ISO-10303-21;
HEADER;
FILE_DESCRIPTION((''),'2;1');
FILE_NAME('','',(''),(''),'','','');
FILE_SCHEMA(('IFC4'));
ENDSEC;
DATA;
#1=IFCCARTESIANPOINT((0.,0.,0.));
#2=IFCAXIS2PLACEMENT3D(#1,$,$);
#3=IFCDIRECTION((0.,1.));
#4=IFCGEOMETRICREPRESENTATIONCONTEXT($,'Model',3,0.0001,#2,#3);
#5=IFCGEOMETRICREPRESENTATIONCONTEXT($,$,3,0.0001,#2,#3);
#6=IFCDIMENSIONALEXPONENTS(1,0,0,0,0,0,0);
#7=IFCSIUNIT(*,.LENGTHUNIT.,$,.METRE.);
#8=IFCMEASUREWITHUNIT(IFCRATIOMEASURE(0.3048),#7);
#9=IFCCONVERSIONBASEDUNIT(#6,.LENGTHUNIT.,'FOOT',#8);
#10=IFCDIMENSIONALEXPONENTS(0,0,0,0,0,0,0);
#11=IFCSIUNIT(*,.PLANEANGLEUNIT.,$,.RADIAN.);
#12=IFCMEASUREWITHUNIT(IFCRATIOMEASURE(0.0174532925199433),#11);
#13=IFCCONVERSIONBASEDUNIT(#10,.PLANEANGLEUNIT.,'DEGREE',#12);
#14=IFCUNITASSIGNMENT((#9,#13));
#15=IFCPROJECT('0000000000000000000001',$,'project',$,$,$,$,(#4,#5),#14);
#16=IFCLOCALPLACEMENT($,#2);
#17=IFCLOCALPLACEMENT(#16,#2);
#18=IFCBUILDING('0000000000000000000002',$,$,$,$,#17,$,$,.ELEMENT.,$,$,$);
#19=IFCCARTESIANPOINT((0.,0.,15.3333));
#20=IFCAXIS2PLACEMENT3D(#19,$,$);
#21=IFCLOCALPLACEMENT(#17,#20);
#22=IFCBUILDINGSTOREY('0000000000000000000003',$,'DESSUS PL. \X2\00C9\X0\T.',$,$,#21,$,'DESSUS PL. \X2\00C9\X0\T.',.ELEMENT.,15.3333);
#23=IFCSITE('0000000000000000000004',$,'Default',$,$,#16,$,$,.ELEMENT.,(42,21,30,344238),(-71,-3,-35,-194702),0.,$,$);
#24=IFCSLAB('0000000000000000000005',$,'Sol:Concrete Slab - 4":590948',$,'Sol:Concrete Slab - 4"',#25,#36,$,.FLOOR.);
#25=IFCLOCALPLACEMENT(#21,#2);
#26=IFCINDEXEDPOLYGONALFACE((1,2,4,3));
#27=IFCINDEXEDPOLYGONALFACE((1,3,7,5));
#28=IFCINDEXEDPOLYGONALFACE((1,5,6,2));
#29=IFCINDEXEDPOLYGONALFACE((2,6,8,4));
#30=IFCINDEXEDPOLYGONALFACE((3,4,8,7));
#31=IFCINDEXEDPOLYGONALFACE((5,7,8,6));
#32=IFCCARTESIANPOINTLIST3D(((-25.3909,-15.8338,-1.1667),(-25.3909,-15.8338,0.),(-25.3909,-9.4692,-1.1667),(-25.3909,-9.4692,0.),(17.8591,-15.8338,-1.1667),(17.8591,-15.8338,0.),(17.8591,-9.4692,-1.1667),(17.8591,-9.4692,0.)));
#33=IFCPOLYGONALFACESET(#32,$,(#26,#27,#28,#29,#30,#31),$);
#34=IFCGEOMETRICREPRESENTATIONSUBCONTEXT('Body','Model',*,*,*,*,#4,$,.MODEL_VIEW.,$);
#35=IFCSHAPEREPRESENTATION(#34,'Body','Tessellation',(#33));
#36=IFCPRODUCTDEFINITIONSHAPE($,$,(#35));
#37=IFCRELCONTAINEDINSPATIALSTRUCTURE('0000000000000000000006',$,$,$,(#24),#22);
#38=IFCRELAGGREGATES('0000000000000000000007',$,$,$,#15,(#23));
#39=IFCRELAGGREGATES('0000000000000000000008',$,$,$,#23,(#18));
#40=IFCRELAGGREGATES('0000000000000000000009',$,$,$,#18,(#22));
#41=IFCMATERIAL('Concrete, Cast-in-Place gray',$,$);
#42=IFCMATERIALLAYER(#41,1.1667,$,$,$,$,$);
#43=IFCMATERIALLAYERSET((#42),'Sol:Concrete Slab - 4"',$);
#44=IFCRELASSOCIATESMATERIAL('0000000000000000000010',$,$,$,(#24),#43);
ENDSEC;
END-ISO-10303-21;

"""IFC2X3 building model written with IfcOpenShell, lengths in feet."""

from ifc_helpers import new_model, entity, si_unit, converted_unit, direction, frame, frame_2d, origin, place, context, subcontext, project, spatial, rectangle, extrude, material, layer, layer_set, layer_usage, element, save


model = new_model("IFC2X3")

# Units and contexts
model_context = context("Model", 3, precision=0.0001, world=origin(), true_north=direction((0.0, 1.0)))
context_of_model = context(None, 3, precision=0.0001, world=origin(), true_north=direction((0.0, 1.0)))
body_context = subcontext(model_context, "Body", "Model", "MODEL_VIEW")
ifc_project = project(units=[converted_unit("LENGTHUNIT", "FOOT", entity("IfcRatioMeasure", 0.3048), si_unit("LENGTHUNIT", "METRE"), dimensions=[1, 0, 0, 0, 0, 0, 0]), converted_unit("PLANEANGLEUNIT", "DEGREE", entity("IfcRatioMeasure", 0.0174532925199433), si_unit("PLANEANGLEUNIT", "RADIAN"), dimensions=[0, 0, 0, 0, 0, 0, 0])], contexts=[model_context, context_of_model])

# Site, building, storey
site_placement = place(None, origin())
site = spatial("IfcSite", under=ifc_project, at=site_placement, Name="Default", CompositionType="ELEMENT", RefLatitude=(42, 21, 30, 344238), RefLongitude=(-71, -3, -35, -194702), RefElevation=0.0)
building_placement = place(site_placement, origin())
building = spatial("IfcBuilding", under=site, at=building_placement, CompositionType="ELEMENT")
storey_placement = place(building_placement, frame((0.0, 0.0, 15.3333)))
storey = spatial("IfcBuildingStorey", under=building, at=storey_placement, Name="DESSUS PL. ÉT.", LongName="DESSUS PL. ÉT.", CompositionType="ELEMENT", Elevation=15.3333)

# Slab
ifc_material_1 = material(Name="Concrete, Cast-in-Place gray")
ifc_layer = layer(ifc_material_1, 1.1667)
ifc_layer_set = layer_set([ifc_layer], Name="Sol:Concrete Slab - 4\"")
ifc_layer_usage = layer_usage(ifc_layer_set, "AXIS3", "POSITIVE", 0.0)
slab_placement = place(storey_placement, origin())
element("IfcSlab", 1, at=slab_placement, inside=storey, material=ifc_layer_usage, Name="Sol:Concrete Slab - 4\":590948", ObjectType="Sol:Concrete Slab - 4\"", PredefinedType="FLOOR", context=body_context, shape_type="SweptSolid", body=[
    extrude(rectangle(XDim=6.3646, YDim=43.25, at=frame_2d((0.0, 0.0), x_axis=(1.0, 0.0))), frame((-3.7659, -12.6515, 0.0), z_axis=(0.0, 0.0, -1.0), x_axis=(0.0, 1.0, 0.0)), (0.0, 0.0, 1.0), 1.1667),
])

save(model, "model.ifc")
